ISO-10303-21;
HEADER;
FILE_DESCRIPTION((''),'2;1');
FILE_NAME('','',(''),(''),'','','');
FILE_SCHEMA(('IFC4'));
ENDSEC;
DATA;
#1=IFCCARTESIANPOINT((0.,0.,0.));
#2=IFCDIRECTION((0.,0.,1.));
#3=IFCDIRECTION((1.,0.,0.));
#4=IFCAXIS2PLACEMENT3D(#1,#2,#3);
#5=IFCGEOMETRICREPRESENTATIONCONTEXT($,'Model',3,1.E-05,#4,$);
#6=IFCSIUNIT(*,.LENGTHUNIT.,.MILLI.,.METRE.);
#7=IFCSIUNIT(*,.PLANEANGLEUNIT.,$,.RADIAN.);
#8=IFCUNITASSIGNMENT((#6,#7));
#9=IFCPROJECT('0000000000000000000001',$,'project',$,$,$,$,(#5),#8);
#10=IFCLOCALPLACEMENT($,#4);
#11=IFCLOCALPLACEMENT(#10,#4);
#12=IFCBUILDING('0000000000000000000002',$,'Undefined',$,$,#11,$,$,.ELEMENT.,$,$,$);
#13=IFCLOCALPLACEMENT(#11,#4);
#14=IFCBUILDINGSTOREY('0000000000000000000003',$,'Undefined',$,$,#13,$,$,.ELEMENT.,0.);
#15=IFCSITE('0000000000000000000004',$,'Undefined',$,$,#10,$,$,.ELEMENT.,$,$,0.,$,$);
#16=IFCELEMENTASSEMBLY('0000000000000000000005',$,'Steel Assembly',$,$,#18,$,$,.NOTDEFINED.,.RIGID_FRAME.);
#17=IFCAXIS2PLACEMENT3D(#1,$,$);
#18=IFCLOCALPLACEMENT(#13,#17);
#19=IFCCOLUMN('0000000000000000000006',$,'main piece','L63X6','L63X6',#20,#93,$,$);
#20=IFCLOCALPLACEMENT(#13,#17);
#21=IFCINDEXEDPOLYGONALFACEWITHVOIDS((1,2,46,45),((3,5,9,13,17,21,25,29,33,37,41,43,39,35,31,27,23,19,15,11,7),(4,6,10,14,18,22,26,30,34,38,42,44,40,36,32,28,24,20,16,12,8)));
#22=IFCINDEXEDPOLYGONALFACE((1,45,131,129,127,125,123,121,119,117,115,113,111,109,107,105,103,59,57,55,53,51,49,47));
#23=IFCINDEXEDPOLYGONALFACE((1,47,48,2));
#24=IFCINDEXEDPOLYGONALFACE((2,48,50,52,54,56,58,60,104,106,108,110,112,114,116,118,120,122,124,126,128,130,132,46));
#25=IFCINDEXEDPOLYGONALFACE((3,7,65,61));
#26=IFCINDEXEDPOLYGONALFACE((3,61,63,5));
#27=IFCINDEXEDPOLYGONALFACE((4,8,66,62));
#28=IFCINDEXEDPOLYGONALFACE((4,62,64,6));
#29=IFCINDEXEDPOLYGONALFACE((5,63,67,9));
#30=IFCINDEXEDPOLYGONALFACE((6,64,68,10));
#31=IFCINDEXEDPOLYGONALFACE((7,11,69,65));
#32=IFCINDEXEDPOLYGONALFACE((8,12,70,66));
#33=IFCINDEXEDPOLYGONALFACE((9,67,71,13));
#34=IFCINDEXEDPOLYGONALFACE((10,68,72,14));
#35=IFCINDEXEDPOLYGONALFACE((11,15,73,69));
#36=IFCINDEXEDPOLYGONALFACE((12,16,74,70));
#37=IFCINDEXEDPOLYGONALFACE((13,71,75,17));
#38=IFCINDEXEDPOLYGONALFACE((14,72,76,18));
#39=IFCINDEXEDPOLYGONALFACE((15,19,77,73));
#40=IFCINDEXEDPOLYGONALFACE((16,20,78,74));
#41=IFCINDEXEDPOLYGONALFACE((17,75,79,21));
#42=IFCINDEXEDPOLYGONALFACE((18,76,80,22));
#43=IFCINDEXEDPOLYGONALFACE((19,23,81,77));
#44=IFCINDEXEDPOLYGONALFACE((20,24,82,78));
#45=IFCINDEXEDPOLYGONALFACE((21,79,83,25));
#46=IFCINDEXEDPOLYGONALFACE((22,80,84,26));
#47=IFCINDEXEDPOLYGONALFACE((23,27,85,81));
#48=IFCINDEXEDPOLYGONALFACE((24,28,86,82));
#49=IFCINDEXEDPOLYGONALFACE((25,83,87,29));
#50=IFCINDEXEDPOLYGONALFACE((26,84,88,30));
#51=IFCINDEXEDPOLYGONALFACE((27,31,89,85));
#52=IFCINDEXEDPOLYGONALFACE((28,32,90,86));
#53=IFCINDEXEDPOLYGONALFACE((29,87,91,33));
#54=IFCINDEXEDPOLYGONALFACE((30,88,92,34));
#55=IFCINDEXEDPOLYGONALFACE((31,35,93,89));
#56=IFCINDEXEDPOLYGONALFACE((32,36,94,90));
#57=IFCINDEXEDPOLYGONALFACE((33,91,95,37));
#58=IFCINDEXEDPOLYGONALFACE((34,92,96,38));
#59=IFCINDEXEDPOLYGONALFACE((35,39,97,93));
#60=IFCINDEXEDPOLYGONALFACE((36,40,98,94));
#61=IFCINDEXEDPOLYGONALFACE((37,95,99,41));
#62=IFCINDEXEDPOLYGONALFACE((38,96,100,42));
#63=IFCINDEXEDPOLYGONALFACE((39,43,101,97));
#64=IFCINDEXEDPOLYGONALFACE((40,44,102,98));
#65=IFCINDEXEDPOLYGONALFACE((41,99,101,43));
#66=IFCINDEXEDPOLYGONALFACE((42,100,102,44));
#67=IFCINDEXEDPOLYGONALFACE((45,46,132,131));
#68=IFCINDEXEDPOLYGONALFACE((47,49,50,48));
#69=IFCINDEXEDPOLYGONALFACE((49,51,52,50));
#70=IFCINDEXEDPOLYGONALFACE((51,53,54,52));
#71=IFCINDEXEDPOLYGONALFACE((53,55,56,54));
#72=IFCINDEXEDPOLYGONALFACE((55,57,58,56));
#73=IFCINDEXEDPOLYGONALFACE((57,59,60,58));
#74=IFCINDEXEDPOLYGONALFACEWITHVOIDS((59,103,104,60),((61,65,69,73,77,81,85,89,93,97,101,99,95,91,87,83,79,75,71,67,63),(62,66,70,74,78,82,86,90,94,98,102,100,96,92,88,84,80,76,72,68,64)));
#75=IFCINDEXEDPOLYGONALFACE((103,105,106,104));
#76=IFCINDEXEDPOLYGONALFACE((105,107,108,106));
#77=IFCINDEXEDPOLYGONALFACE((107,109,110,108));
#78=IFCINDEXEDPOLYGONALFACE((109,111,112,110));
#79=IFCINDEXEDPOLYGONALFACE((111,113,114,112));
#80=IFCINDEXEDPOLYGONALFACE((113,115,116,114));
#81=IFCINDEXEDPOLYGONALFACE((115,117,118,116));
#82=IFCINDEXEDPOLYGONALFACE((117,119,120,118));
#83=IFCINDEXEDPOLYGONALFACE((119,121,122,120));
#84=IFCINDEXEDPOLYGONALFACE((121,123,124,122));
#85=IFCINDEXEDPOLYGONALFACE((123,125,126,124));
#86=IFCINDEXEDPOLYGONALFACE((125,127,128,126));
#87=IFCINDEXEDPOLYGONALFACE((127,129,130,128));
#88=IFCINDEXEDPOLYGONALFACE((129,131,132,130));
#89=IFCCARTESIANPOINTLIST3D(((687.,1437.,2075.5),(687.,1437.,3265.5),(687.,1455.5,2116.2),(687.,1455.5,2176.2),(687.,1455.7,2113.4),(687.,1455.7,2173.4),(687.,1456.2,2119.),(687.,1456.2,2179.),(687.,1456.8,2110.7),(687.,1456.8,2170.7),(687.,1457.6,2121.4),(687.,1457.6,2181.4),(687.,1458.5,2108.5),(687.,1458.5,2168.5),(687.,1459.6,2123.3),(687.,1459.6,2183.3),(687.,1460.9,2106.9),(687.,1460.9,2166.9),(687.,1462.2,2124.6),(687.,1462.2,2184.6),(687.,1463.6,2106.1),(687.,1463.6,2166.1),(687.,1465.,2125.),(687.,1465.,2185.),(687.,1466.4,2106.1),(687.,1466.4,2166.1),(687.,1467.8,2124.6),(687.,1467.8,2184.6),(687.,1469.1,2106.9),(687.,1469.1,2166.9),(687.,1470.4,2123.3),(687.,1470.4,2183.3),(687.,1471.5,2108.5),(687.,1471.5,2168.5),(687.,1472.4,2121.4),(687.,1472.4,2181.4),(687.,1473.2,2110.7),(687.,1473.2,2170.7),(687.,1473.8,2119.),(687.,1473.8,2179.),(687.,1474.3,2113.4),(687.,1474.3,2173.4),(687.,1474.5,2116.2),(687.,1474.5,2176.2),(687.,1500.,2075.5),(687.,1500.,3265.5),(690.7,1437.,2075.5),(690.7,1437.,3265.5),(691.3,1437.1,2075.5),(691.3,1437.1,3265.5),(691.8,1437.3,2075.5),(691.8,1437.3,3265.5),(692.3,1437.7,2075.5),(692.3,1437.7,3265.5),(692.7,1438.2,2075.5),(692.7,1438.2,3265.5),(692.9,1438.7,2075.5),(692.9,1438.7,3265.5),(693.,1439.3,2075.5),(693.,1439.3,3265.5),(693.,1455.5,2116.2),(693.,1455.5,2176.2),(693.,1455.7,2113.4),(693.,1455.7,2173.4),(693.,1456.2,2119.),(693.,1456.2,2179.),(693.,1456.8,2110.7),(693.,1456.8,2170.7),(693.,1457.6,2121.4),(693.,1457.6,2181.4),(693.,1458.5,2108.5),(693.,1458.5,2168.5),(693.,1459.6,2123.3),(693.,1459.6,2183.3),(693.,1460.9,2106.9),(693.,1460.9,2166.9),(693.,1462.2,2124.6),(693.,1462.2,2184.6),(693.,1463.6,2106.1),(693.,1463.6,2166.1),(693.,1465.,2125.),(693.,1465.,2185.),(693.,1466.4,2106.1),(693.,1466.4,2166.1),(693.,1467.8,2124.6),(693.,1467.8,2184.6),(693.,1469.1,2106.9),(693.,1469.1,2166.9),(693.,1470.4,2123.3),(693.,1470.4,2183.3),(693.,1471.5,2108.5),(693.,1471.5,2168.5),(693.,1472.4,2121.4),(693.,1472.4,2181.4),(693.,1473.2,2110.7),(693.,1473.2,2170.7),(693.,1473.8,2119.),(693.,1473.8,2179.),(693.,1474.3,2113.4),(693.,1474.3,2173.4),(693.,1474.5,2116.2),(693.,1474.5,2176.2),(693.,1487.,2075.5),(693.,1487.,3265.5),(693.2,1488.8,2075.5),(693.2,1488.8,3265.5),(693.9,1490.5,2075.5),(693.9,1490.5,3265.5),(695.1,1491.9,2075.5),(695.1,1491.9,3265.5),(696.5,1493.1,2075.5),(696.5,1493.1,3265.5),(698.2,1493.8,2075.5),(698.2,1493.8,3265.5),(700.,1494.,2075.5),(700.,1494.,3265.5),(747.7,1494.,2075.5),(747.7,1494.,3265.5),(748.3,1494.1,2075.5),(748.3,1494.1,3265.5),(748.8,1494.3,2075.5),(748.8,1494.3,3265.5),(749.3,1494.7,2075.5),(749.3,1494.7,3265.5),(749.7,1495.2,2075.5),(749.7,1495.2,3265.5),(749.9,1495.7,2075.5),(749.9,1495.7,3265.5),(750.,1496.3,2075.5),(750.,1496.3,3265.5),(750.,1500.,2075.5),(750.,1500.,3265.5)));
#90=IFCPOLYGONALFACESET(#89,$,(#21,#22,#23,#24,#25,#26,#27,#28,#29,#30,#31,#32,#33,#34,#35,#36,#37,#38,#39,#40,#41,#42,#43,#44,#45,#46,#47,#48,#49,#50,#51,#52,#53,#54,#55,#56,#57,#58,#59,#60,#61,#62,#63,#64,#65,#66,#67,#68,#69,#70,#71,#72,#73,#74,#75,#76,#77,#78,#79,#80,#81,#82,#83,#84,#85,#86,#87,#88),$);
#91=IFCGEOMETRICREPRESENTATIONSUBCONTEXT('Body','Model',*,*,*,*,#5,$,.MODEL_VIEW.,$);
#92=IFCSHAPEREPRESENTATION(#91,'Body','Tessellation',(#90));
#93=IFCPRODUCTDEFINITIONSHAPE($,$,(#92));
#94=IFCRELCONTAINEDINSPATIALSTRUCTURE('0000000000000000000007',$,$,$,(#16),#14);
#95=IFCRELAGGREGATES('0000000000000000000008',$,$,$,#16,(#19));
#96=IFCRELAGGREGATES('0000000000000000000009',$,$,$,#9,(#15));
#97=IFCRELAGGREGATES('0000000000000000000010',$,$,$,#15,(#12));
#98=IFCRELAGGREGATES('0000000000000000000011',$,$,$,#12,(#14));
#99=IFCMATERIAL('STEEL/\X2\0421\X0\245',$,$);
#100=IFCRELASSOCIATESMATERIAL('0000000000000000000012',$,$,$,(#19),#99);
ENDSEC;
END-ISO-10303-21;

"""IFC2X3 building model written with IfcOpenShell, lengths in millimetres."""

from ifc_helpers import new_model, si_unit, frame, origin_with_axes, origin_2d_with_axis, place, context, subcontext, project, spatial, circle, l_section, extrude, source, transform, mapped, material, element, aggregate, save


model = new_model("IFC2X3")

# Units and contexts
model_context = context("Model", 3, precision=1e-05, world=origin_with_axes())
body_context = subcontext(model_context, "Body", "Model", "MODEL_VIEW")
ifc_project = project(units=[si_unit("LENGTHUNIT", "METRE", prefix="MILLI"), si_unit("PLANEANGLEUNIT", "RADIAN")], contexts=[model_context])

# Site, building, storey
site_placement = place(None, origin_with_axes())
site = spatial("IfcSite", under=ifc_project, at=site_placement, Name="Undefined", CompositionType="ELEMENT", RefElevation=0.0)
building_placement = place(site_placement, origin_with_axes())
building = spatial("IfcBuilding", under=site, at=building_placement, Name="Undefined", CompositionType="ELEMENT")
storey_placement = place(building_placement, origin_with_axes())
storey = spatial("IfcBuildingStorey", under=building, at=storey_placement, Name="Undefined", CompositionType="ELEMENT", Elevation=0.0)

# Element assembly, column, opening
assembly_1_placement = place(storey_placement, origin_with_axes())
assembly_1 = element("IfcElementAssembly", 1, at=assembly_1_placement, inside=storey, Name="Steel Assembly", AssemblyPlace="NOTDEFINED", PredefinedType="RIGID_FRAME")
ifc_material_1 = material(Name="STEEL/С245")
column_placement = place(assembly_1_placement, frame((718.5, 1468.5, 2075.5), z_axis=(0.0, 0.0, 1.0), x_axis=(1.0, 0.0, 0.0)))
column = element("IfcColumn", 2, at=column_placement, material=ifc_material_1, Name="main piece", Description="L63X6", ObjectType="L63X6", context=body_context, shape_type="SweptSolid", body=[
    extrude(l_section(Depth=63.0, Width=63.0, Thickness=6.0, FilletRadius=7.0, EdgeRadius=2.3, at=origin_2d_with_axis()), frame((0.0, 0.0, 1190.0), z_axis=(0.0, 0.0, -1.0), x_axis=(1.0, 0.0, 0.0)), (0.0, 0.0, 1.0), 1190.0),
])
shared_shape_1 = source(origin_with_axes(), body_context, "Body", "SweptSolid", [
    extrude(circle(Radius=9.5, at=origin_2d_with_axis()), frame((0.0, -0.1, 0.0), z_axis=(0.0, 1.0, 0.0), x_axis=(1.0, 0.0, 0.0)), (0.0, 0.0, 1.0), 6.2),
])
opening_1_placement = place(assembly_1_placement, frame((687.0, 1465.0, 2115.5), z_axis=(0.0, 1.0, 0.0), x_axis=(0.0, 0.0, 1.0)))
element("IfcOpeningElement", 3, at=opening_1_placement, cuts=column, ObjectType="Opening", context=body_context, shape_type="MappedRepresentation", body=[
    mapped(shared_shape_1, transform((0.0, 0.0, 0.0))),
    mapped(shared_shape_1, transform((60.0, 0.0, 0.0))),
])

aggregate(assembly_1, [column])

save(model, "model.ifc")
